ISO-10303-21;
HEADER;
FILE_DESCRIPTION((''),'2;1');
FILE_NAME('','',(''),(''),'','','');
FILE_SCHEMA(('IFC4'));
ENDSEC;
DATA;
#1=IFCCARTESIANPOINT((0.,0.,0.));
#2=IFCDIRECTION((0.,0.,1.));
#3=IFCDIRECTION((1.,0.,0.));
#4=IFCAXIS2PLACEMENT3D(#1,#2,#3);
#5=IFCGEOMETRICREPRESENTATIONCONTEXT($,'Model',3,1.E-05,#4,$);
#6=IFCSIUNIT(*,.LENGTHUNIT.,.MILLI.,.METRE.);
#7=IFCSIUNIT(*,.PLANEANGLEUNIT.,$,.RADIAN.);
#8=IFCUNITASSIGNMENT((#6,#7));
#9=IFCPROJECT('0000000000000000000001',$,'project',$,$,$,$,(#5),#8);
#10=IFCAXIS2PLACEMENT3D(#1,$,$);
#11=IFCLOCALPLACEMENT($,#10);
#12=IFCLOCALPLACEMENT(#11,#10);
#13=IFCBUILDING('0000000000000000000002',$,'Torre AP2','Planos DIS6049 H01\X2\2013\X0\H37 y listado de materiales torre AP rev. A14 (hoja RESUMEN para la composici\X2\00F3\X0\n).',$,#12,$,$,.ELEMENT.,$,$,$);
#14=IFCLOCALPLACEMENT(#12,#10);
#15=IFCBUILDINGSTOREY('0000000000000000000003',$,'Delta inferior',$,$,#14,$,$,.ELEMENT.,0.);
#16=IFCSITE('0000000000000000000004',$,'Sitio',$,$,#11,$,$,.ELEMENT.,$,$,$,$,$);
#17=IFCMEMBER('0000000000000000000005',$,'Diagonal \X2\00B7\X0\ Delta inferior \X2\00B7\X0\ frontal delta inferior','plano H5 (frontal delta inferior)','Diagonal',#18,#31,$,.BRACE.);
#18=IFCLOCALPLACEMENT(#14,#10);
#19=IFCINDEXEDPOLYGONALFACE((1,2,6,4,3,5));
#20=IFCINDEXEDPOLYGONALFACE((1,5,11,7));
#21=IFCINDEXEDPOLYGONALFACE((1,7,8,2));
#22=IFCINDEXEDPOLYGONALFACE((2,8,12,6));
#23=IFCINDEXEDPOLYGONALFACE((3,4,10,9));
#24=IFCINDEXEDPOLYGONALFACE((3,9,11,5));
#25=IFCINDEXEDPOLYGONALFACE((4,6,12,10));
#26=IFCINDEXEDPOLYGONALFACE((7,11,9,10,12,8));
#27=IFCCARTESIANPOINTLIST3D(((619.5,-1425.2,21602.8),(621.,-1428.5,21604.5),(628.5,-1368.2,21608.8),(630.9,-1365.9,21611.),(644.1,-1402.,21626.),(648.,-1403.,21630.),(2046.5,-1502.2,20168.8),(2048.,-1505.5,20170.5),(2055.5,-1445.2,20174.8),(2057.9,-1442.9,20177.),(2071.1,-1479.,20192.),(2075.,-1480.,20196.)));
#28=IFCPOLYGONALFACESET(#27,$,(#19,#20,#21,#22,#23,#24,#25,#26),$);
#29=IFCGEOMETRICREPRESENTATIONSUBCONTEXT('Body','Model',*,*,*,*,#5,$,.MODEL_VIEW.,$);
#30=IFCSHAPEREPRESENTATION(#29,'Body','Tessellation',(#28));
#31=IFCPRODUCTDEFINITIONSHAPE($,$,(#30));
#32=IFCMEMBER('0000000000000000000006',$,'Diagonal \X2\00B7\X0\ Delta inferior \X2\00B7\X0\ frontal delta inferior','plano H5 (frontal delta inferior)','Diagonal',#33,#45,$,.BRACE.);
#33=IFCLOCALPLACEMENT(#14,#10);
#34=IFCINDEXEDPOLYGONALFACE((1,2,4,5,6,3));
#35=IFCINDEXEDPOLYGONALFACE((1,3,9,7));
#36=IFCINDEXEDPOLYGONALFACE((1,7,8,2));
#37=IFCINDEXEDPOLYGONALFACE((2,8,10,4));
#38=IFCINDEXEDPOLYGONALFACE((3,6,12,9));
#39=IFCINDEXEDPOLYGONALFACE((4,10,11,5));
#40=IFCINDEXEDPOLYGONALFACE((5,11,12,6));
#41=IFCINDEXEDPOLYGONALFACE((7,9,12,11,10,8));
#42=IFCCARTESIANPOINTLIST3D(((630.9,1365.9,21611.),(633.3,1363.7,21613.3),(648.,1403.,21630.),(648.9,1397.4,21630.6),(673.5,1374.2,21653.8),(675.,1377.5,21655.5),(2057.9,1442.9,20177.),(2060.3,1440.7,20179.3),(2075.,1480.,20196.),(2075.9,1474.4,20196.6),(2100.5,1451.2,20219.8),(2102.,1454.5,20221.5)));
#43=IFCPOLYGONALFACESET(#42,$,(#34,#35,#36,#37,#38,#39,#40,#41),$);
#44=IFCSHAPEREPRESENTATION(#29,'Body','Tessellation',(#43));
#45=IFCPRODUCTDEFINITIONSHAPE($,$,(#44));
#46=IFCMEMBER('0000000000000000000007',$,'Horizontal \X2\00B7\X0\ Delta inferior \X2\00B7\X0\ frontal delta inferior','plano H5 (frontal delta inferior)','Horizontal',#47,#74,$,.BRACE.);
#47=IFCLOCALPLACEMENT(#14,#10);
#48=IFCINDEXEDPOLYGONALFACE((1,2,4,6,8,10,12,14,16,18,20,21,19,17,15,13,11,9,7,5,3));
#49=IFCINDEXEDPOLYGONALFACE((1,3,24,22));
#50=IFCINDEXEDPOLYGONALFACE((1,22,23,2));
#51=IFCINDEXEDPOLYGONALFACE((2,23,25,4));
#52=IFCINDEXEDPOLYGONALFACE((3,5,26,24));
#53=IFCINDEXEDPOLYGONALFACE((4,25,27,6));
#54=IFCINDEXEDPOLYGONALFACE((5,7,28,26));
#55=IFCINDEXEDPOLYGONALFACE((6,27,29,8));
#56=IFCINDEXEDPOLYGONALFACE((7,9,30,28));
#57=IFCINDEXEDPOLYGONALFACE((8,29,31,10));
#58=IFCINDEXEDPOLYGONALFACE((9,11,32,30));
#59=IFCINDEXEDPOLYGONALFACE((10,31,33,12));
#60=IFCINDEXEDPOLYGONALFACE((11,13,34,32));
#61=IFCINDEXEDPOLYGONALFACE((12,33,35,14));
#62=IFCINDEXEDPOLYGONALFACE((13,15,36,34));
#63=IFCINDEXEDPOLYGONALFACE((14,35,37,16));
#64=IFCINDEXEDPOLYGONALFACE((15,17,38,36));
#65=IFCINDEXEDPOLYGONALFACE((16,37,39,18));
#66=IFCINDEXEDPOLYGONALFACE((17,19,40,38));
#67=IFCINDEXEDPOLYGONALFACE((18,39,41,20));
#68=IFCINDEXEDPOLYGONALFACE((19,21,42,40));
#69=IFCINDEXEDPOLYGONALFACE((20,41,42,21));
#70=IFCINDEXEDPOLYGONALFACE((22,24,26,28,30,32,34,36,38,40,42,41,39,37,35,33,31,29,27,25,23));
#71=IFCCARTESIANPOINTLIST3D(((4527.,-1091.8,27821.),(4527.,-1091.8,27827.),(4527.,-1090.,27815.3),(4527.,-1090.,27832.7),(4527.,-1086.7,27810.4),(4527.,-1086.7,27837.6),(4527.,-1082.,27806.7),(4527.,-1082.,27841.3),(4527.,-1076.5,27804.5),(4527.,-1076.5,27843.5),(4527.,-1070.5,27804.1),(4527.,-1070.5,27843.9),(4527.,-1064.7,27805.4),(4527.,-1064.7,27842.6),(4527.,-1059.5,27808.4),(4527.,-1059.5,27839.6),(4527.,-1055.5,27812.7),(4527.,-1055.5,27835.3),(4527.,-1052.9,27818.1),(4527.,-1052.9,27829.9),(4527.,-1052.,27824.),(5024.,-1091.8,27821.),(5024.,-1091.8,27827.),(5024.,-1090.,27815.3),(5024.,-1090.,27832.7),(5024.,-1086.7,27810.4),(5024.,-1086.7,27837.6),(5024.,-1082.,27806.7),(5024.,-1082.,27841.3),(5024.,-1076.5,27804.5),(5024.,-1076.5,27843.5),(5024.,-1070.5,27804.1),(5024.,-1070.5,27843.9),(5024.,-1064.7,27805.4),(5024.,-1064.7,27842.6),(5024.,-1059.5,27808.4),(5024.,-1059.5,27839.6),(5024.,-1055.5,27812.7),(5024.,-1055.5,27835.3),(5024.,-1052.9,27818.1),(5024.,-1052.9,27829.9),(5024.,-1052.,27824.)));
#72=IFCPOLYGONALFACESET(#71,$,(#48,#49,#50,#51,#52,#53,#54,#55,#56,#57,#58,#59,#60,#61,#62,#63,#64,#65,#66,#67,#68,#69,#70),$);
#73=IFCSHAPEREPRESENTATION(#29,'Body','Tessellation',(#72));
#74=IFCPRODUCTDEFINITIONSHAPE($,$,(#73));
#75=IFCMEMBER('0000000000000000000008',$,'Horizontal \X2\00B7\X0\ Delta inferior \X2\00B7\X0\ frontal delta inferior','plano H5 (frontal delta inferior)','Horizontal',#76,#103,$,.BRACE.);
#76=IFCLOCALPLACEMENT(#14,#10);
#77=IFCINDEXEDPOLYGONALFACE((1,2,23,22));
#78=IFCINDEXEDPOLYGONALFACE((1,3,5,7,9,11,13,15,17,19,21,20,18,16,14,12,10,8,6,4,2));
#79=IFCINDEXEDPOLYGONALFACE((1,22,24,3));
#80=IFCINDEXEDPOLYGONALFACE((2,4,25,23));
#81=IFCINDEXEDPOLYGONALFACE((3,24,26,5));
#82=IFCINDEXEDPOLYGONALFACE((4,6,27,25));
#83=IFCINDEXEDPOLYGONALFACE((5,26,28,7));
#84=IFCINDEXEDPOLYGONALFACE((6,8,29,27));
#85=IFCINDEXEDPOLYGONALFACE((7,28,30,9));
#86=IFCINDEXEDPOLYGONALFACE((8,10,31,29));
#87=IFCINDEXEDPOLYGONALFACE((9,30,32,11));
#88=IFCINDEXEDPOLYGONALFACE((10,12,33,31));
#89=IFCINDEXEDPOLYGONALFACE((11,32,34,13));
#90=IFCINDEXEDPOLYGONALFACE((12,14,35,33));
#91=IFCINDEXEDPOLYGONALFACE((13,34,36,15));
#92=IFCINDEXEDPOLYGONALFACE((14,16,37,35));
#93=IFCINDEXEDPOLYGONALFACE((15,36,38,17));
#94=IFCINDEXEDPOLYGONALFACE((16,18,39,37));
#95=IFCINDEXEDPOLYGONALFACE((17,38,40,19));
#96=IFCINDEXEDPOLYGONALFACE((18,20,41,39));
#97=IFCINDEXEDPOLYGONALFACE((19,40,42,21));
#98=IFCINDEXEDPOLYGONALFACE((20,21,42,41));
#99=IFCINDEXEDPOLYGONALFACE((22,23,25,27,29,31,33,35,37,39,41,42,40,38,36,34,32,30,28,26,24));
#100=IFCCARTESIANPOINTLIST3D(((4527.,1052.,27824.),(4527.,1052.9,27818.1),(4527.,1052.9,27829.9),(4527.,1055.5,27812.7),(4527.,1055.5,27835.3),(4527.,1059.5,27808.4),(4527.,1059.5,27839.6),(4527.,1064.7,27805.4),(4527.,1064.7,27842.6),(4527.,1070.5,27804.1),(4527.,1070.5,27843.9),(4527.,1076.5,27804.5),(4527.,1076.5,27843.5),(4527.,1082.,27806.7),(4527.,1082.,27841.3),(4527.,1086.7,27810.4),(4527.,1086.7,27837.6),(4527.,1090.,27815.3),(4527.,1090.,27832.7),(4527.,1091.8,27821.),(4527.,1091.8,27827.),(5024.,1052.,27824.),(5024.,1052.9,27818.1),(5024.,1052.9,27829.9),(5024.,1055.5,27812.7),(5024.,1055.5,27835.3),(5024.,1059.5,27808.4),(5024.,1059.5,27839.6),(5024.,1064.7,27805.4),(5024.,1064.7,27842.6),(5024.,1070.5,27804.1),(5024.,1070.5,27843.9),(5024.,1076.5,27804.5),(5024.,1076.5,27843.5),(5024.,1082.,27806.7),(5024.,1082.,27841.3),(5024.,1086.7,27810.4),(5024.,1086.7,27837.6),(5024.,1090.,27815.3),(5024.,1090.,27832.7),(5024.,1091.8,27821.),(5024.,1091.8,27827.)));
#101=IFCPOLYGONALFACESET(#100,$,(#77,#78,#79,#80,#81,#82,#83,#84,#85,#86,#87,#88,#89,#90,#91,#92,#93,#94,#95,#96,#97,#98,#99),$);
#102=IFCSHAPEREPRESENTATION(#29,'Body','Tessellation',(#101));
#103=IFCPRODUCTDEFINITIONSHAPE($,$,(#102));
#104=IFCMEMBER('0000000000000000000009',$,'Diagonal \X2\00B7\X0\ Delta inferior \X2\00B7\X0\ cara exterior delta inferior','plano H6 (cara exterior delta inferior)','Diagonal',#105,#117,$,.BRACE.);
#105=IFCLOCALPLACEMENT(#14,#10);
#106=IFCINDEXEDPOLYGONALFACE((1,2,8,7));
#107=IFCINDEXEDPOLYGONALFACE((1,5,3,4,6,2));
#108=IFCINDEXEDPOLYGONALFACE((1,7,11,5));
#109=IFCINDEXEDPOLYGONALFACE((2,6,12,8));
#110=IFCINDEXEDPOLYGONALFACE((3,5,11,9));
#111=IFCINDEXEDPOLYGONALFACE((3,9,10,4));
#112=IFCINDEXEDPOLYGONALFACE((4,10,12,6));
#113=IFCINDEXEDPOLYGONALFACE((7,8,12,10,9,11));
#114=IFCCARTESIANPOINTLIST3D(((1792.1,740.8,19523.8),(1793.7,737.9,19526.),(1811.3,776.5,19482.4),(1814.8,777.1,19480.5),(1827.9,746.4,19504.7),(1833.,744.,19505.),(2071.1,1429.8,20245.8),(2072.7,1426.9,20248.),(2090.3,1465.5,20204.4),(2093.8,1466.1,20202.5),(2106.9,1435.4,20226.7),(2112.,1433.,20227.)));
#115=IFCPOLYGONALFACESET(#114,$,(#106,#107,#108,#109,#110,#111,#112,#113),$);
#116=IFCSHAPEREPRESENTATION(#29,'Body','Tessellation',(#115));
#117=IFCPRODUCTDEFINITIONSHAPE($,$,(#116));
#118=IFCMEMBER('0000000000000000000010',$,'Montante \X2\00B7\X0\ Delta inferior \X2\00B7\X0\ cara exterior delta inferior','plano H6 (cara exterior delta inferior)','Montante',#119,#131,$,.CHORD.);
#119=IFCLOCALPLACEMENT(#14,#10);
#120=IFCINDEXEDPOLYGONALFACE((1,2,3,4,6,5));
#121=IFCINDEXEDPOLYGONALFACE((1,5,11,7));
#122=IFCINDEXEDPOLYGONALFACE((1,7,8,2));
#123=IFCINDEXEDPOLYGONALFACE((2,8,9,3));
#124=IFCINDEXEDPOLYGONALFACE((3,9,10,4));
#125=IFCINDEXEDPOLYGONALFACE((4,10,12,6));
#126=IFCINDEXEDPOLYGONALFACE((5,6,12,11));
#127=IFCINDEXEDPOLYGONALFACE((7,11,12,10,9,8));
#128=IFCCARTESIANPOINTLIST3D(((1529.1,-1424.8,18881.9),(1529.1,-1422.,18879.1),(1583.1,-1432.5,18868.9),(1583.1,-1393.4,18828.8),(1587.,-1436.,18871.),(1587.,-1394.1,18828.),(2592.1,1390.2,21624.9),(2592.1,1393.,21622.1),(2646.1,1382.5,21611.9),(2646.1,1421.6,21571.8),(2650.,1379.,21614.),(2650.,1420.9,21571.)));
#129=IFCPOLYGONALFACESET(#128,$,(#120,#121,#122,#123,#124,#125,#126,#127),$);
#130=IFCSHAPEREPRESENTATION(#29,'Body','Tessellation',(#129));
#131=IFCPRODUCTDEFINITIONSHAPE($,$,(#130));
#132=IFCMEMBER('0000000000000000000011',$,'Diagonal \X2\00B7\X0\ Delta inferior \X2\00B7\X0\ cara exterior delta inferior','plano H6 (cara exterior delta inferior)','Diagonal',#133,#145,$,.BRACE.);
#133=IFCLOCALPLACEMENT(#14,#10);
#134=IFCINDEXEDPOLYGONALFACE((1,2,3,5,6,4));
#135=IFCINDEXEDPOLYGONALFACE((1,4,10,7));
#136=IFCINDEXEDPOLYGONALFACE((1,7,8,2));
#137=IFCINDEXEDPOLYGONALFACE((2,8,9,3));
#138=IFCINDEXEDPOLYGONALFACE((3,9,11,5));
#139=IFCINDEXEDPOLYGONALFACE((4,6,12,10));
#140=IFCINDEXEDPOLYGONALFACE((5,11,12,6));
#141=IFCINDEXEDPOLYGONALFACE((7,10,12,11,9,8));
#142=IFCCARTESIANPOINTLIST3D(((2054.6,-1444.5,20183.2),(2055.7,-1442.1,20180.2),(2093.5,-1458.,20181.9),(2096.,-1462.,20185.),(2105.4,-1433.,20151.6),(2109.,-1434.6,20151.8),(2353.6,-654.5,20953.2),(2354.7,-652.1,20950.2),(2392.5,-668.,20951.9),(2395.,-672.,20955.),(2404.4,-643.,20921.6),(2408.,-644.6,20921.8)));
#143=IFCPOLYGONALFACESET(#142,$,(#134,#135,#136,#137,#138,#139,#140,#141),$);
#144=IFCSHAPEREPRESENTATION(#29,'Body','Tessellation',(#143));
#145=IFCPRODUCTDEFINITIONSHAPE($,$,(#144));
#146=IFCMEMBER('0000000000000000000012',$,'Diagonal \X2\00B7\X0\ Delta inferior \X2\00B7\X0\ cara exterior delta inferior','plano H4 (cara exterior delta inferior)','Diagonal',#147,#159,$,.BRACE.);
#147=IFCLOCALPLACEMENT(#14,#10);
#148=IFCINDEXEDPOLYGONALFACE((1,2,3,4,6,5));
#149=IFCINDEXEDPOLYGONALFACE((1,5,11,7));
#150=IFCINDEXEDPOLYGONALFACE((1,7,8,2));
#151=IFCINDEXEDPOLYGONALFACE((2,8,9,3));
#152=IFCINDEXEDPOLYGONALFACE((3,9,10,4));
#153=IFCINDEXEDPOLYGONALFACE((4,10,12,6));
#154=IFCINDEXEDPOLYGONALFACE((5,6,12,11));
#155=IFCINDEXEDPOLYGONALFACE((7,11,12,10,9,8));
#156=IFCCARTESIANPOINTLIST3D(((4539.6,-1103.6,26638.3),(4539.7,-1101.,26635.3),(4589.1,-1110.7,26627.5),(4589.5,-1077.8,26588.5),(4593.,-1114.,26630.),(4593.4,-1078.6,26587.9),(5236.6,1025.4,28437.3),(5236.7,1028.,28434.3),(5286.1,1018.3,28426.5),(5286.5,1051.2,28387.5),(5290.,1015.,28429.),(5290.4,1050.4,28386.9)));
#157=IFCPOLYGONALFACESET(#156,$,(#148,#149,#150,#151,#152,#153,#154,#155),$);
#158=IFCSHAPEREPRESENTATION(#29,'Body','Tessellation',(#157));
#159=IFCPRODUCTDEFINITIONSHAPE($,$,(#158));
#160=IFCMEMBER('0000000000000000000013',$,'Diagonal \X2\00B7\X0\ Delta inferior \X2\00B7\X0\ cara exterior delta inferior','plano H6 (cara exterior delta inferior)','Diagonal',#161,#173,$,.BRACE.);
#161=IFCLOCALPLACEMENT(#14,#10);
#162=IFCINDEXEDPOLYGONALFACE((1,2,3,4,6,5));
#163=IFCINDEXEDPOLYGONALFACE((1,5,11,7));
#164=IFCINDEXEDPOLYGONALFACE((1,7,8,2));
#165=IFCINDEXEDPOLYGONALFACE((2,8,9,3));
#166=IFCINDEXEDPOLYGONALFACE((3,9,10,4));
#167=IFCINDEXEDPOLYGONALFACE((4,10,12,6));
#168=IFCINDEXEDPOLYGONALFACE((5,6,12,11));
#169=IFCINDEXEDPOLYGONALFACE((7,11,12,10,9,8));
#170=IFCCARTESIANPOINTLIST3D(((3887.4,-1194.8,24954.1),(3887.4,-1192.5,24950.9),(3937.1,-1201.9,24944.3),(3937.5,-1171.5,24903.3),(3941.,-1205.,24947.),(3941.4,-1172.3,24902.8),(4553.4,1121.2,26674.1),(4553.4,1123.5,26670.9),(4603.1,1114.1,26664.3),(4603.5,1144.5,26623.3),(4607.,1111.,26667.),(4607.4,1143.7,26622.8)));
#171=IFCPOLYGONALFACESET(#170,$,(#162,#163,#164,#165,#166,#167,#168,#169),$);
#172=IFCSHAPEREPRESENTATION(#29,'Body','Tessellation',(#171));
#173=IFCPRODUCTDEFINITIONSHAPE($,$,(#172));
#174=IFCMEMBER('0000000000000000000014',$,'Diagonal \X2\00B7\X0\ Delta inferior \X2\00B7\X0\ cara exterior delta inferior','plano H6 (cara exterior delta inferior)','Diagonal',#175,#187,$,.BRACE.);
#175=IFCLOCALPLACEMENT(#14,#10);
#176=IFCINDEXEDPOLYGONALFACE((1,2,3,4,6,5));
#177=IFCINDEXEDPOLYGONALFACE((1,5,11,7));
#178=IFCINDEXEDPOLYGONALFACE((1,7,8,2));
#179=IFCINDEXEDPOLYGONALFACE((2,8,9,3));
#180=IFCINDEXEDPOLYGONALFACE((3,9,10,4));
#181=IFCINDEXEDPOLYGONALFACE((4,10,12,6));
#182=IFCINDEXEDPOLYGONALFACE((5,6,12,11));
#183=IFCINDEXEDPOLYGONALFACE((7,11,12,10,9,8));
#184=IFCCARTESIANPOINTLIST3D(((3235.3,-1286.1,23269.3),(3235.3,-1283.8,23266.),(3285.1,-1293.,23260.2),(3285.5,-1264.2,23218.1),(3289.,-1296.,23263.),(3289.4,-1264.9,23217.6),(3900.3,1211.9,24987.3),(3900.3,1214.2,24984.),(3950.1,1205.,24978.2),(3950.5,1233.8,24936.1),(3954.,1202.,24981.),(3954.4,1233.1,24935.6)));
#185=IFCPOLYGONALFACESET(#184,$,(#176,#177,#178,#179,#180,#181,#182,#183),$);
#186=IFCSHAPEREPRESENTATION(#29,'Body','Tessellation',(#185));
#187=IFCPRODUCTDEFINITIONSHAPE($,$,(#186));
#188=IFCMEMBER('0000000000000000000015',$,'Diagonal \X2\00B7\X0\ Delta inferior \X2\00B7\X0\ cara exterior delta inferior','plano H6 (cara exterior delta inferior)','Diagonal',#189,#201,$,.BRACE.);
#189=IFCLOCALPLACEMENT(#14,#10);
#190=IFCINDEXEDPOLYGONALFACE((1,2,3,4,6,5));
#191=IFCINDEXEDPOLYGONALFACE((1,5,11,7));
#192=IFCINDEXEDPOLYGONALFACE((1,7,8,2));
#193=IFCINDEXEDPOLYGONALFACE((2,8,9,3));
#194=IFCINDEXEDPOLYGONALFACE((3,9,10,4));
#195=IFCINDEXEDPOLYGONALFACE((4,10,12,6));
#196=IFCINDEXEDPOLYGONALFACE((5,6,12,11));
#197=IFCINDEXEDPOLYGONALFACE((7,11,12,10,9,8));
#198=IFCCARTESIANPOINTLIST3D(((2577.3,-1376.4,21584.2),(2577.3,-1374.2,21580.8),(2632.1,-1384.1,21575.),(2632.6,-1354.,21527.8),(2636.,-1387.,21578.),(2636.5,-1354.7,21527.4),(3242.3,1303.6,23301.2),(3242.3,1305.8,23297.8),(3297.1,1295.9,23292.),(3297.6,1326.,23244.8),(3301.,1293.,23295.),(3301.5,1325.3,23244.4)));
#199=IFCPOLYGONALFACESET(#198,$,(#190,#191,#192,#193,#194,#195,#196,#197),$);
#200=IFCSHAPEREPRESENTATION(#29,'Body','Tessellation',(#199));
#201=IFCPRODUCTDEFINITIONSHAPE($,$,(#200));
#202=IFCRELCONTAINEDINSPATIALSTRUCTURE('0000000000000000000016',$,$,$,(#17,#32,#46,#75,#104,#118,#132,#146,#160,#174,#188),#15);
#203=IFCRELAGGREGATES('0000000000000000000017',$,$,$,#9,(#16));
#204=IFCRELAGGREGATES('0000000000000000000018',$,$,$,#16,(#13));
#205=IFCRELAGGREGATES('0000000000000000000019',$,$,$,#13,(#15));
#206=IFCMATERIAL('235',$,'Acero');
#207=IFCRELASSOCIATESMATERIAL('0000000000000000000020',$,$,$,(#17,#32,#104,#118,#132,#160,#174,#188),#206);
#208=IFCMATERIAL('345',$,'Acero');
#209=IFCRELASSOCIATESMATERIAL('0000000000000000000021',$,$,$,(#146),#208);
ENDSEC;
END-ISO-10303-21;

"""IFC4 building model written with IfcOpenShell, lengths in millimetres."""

from ifc_helpers import new_model, si_unit, frame, frame_2d, origin, origin_with_axes, place, context, subcontext, project, spatial, circle, l_section, extrude, material, element, save


model = new_model("IFC4")

# Units and contexts
model_context = context("Model", 3, precision=1e-05, world=origin_with_axes())
body_context = subcontext(model_context, "Body", "Model", "MODEL_VIEW")
ifc_project = project(units=[si_unit("LENGTHUNIT", "METRE", prefix="MILLI"), si_unit("PLANEANGLEUNIT", "RADIAN")], contexts=[model_context])

# Site, building, storey
site_placement = place(None, origin())
site = spatial("IfcSite", under=ifc_project, at=site_placement, Name="Sitio", CompositionType="ELEMENT")
building_placement = place(site_placement, origin())
building = spatial("IfcBuilding", under=site, at=building_placement, Name="Torre AP2", Description="Planos DIS6049 H01–H37 y listado de materiales torre AP rev. A14 (hoja RESUMEN para la composición).", CompositionType="ELEMENT")
storey_placement = place(building_placement, origin())
storey = spatial("IfcBuildingStorey", under=building, at=storey_placement, Name="Delta inferior", CompositionType="ELEMENT", Elevation=0.0)

# Members
ifc_material_1 = material(Name="235", Category="Acero")
for number, where, z_axis, x_axis, name in (
    (1, (2075.0, -1480.0, 20196.0), (-0.704864, 0.038034, 0.708322), (-0.379432, 0.82348, -0.421797), "Diagonal · Delta inferior · frontal delta inferior"),
    (2, (2075.0, 1480.0, 20196.0), (-0.704864, -0.038034, 0.708322), (-0.379432, -0.82348, -0.421797), "Diagonal · Delta inferior · frontal delta inferior"),
):
    element("IfcMember", number, at=place(storey_placement, frame(where, z_axis=z_axis, x_axis=x_axis)), inside=storey, material=ifc_material_1, Name=name, Description="plano H5 (frontal delta inferior)", ObjectType="Diagonal", PredefinedType="BRACE", context=body_context, shape_type="SweptSolid", body=[
        extrude(l_section(Depth=45.0, Width=45.0, Thickness=4.0, at=frame_2d((22.5, 22.5))), None, (0.0, 0.0, 1.0), 2024.5),
    ])
for number, where, z_axis, x_axis, name in (
    (3, (5024.0, -1072.0, 27824.0), (-1.0, 0.0, 0.0), (0.0, 1.0, 0.0), "Horizontal · Delta inferior · frontal delta inferior"),
    (4, (5024.0, 1072.0, 27824.0), (-1.0, 0.0, 0.0), (0.0, -1.0, 0.0), "Horizontal · Delta inferior · frontal delta inferior"),
):
    element("IfcMember", number, at=place(storey_placement, frame(where, z_axis=z_axis, x_axis=x_axis)), inside=storey, Name=name, Description="plano H5 (frontal delta inferior)", ObjectType="Horizontal", PredefinedType="BRACE", context=body_context, shape_type="SweptSolid", body=[
        extrude(circle(Radius=20.0), None, (0.0, 0.0, 1.0), 497.0),
    ])
member_1_placement = place(storey_placement, frame((2112.0, 1433.0, 20227.0), z_axis=(-0.269236, -0.664888, -0.696733), x_axis=(-0.873631, -0.135855, 0.46724)))
element("IfcMember", 5, at=member_1_placement, inside=storey, material=ifc_material_1, Name="Diagonal · Delta inferior · cara exterior delta inferior", Description="plano H6 (cara exterior delta inferior)", ObjectType="Diagonal", PredefinedType="BRACE", context=body_context, shape_type="SweptSolid", body=[
    extrude(l_section(Depth=45.0, Width=45.0, Thickness=4.0, at=frame_2d((22.5, 22.5))), None, (0.0, 0.0, 1.0), 1036.3),
])
member_2_placement = place(storey_placement, frame((2650.0, 1379.0, 21614.0), z_axis=(-0.261074, -0.691368, -0.673685), x_axis=(-0.965319, 0.186983, 0.182201)))
element("IfcMember", 6, at=member_2_placement, inside=storey, material=ifc_material_1, Name="Montante · Delta inferior · cara exterior delta inferior", Description="plano H6 (cara exterior delta inferior)", ObjectType="Montante", PredefinedType="CHORD", context=body_context, shape_type="SweptSolid", body=[
    extrude(l_section(Depth=60.0, Width=60.0, Thickness=4.0, at=frame_2d((30.0, 30.0))), None, (0.0, 0.0, 1.0), 4071.6),
])
member_3_placement = place(storey_placement, frame((2395.0, -672.0, 20955.0), z_axis=(-0.261597, -0.691176, -0.673678), x_axis=(-0.920687, 0.38817, -0.040739)))
element("IfcMember", 7, at=member_3_placement, inside=storey, material=ifc_material_1, Name="Diagonal · Delta inferior · cara exterior delta inferior", Description="plano H6 (cara exterior delta inferior)", ObjectType="Diagonal", PredefinedType="BRACE", context=body_context, shape_type="SweptSolid", body=[
    extrude(l_section(Depth=45.0, Width=45.0, Thickness=4.0, at=frame_2d((22.5, 22.5))), None, (0.0, 0.0, 1.0), 1143.0),
])
ifc_material_2 = material(Name="345", Category="Acero")
member_4_placement = place(storey_placement, frame((5290.0, 1015.0, 28429.0), z_axis=(-0.242593, -0.741005, -0.626147), x_axis=(-0.970107, 0.189587, 0.151492)))
element("IfcMember", 8, at=member_4_placement, inside=storey, material=ifc_material_2, Name="Diagonal · Delta inferior · cara exterior delta inferior", Description="plano H4 (cara exterior delta inferior)", ObjectType="Diagonal", PredefinedType="BRACE", context=body_context, shape_type="SweptSolid", body=[
    extrude(l_section(Depth=55.0, Width=55.0, Thickness=4.0, at=frame_2d((27.5, 27.5))), None, (0.0, 0.0, 1.0), 2873.1),
])
member_5_placement = place(storey_placement, frame((4607.0, 1111.0, 26667.0), z_axis=(-0.224946, -0.782244, -0.580941), x_axis=(-0.974349, 0.184591, 0.128724)))
element("IfcMember", 9, at=member_5_placement, inside=storey, material=ifc_material_1, Name="Diagonal · Delta inferior · cara exterior delta inferior", Description="plano H6 (cara exterior delta inferior)", ObjectType="Diagonal", PredefinedType="BRACE", context=body_context, shape_type="SweptSolid", body=[
    extrude(l_section(Depth=55.0, Width=55.0, Thickness=4.0, at=frame_2d((27.5, 27.5))), None, (0.0, 0.0, 1.0), 2960.7),
])
member_6_placement = place(storey_placement, frame((3954.0, 1202.0, 24981.0), z_axis=(-0.214252, -0.804812, -0.55351), x_axis=(-0.976751, 0.180783, 0.115217)))
element("IfcMember", 10, at=member_6_placement, inside=storey, material=ifc_material_1, Name="Diagonal · Delta inferior · cara exterior delta inferior", Description="plano H6 (cara exterior delta inferior)", ObjectType="Diagonal", PredefinedType="BRACE", context=body_context, shape_type="SweptSolid", body=[
    extrude(l_section(Depth=55.0, Width=55.0, Thickness=4.0, at=frame_2d((27.5, 27.5))), None, (0.0, 0.0, 1.0), 3103.8),
])
member_7_placement = place(storey_placement, frame((3301.0, 1293.0, 23295.0), z_axis=(-0.204517, -0.824217, -0.528052), x_axis=(-0.978826, 0.176893, 0.102997)))
element("IfcMember", 11, at=member_7_placement, inside=storey, material=ifc_material_1, Name="Diagonal · Delta inferior · cara exterior delta inferior", Description="plano H6 (cara exterior delta inferior)", ObjectType="Diagonal", PredefinedType="BRACE", context=body_context, shape_type="SweptSolid", body=[
    extrude(l_section(Depth=60.0, Width=60.0, Thickness=4.0, at=frame_2d((30.0, 30.0))), None, (0.0, 0.0, 1.0), 3251.6),
])

save(model, "model.ifc")
